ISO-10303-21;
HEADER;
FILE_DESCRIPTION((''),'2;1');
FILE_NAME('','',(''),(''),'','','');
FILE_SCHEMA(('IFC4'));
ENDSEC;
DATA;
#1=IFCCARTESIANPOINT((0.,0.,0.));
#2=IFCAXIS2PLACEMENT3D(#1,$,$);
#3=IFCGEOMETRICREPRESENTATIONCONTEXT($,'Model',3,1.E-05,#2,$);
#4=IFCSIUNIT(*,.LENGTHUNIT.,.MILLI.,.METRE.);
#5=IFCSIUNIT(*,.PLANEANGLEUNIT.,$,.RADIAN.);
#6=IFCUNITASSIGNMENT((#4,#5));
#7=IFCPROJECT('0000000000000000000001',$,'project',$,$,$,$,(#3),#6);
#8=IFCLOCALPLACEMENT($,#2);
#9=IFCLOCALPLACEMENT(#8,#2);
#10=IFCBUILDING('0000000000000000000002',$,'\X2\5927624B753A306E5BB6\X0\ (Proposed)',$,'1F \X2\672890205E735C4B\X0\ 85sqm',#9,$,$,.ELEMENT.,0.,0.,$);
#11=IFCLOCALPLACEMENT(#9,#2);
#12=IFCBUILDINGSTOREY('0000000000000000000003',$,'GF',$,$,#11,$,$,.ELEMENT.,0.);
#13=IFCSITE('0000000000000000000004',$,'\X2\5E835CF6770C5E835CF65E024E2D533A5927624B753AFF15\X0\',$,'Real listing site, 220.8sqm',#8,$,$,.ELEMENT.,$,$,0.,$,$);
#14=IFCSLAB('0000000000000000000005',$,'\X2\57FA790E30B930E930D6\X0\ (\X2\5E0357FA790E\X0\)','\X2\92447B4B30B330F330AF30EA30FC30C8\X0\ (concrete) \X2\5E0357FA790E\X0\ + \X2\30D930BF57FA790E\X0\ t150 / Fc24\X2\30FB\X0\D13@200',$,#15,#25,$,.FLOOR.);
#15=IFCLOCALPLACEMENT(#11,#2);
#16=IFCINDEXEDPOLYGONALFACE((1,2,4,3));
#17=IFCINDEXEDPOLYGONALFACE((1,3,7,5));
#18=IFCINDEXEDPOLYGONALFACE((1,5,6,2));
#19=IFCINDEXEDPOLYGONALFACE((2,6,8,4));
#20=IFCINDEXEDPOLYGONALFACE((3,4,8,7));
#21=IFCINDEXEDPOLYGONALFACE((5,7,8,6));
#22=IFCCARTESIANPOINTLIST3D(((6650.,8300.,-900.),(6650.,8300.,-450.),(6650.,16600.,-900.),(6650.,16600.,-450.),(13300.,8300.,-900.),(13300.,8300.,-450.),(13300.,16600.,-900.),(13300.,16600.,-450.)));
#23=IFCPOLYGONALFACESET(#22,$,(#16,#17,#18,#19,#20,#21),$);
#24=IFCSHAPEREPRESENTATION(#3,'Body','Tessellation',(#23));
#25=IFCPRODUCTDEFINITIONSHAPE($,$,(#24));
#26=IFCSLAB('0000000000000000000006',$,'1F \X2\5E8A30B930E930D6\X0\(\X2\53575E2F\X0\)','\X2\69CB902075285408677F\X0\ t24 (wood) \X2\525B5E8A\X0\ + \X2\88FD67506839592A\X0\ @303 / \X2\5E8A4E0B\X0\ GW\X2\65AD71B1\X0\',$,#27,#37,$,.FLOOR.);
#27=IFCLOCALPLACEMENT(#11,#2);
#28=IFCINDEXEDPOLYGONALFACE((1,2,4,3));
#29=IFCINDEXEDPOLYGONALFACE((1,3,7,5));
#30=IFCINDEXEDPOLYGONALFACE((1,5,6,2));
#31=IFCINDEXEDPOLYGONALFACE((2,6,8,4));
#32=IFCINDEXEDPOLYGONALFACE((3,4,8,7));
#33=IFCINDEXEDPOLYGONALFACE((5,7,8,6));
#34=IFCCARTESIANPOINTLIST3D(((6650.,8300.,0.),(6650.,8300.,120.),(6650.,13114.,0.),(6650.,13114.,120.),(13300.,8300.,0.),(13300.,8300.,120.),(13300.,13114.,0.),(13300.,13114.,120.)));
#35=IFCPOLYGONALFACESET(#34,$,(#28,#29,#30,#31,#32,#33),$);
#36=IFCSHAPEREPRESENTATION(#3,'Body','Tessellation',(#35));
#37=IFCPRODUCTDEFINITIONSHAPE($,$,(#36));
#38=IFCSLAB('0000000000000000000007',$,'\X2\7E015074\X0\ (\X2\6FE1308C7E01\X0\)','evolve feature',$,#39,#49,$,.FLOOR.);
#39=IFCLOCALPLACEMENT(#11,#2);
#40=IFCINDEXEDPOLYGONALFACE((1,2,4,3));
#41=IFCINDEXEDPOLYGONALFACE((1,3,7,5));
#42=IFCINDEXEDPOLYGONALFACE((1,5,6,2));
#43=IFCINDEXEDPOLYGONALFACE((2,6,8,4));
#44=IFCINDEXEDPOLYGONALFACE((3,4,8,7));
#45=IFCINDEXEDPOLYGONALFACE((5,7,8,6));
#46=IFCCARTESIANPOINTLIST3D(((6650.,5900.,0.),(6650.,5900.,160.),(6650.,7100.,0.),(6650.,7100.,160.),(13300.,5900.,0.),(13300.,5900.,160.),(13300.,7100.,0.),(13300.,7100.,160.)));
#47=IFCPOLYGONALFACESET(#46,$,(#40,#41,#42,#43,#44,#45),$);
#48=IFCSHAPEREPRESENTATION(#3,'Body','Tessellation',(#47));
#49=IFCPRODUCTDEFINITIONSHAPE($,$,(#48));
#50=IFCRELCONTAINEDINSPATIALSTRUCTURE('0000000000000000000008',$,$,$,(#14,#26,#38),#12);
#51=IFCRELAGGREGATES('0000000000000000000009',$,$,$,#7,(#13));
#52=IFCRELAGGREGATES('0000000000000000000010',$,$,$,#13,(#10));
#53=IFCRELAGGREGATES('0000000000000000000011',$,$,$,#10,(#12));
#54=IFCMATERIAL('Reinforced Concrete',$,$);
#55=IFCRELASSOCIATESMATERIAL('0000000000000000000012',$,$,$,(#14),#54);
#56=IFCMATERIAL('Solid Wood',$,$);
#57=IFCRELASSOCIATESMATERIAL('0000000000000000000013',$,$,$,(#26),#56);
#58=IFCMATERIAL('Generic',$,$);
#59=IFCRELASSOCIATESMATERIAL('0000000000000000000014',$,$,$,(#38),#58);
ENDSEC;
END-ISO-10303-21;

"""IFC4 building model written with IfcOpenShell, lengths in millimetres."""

from ifc_helpers import new_model, si_unit, frame, frame_2d, origin, place, context, project, spatial, rectangle, extrude, material, element, save


model = new_model("IFC4")

# Units and contexts
model_context = context("Model", 3, precision=1e-05, world=origin())
ifc_project = project(units=[si_unit("LENGTHUNIT", "METRE", prefix="MILLI"), si_unit("PLANEANGLEUNIT", "RADIAN")], contexts=[model_context])

# Site, building, storey
site_placement = place(None, origin())
site = spatial("IfcSite", under=ifc_project, at=site_placement, Name="広島県広島市中区大手町５", ObjectType="Real listing site, 220.8sqm", CompositionType="ELEMENT", RefElevation=0.0)
building_placement = place(site_placement, origin())
building = spatial("IfcBuilding", under=site, at=building_placement, Name="大手町の家 (Proposed)", ObjectType="1F 木造平屋 85sqm", CompositionType="ELEMENT", ElevationOfRefHeight=0.0, ElevationOfTerrain=0.0)
storey_placement = place(building_placement, origin())
storey = spatial("IfcBuildingStorey", under=building, at=storey_placement, Name="GF", CompositionType="ELEMENT", Elevation=0.0)

# Slabs
ifc_material_1 = material(Name="Reinforced Concrete")
slab_1_placement = place(storey_placement, frame((3325.0, 4150.0, -450.0)))
element("IfcSlab", 1, at=slab_1_placement, inside=storey, material=ifc_material_1, Name="基礎スラブ (布基礎)", Description="鉄筋コンクリート (concrete) 布基礎 + ベタ基礎 t150 / Fc24・D13@200", PredefinedType="FLOOR", context=model_context, shape_type="SweptSolid", body=[
    extrude(rectangle(XDim=6650.0, YDim=8300.0, at=frame_2d((3325.0, 4150.0))), frame((3325.0, 4150.0, -450.0)), (0.0, 0.0, 1.0), 450.0),
])
ifc_material_2 = material(Name="Solid Wood")
slab_2_placement = place(storey_placement, frame((3325.0, 4150.0, 0.0)))
element("IfcSlab", 2, at=slab_2_placement, inside=storey, material=ifc_material_2, Name="1F 床スラブ(南帯)", Description="構造用合板 t24 (wood) 剛床 + 製材根太 @303 / 床下 GW断熱", PredefinedType="FLOOR", context=model_context, shape_type="SweptSolid", body=[
    extrude(rectangle(XDim=6650.0, YDim=4814.0, at=frame_2d((3325.0, 2407.0))), frame((3325.0, 4150.0, 0.0)), (0.0, 0.0, 1.0), 120.0),
])
ifc_material_3 = material(Name="Generic")
slab_3_placement = place(storey_placement, frame((3325.0, 2950.0, 0.0)))
element("IfcSlab", 3, at=slab_3_placement, inside=storey, material=ifc_material_3, Name="縁側 (濡れ縁)", Description="evolve feature", PredefinedType="FLOOR", context=model_context, shape_type="SweptSolid", body=[
    extrude(rectangle(XDim=6650.0, YDim=1200.0, at=frame_2d((3325.0, 600.0))), frame((3325.0, 2950.0, 0.0)), (0.0, 0.0, 1.0), 160.0),
])

save(model, "model.ifc")
